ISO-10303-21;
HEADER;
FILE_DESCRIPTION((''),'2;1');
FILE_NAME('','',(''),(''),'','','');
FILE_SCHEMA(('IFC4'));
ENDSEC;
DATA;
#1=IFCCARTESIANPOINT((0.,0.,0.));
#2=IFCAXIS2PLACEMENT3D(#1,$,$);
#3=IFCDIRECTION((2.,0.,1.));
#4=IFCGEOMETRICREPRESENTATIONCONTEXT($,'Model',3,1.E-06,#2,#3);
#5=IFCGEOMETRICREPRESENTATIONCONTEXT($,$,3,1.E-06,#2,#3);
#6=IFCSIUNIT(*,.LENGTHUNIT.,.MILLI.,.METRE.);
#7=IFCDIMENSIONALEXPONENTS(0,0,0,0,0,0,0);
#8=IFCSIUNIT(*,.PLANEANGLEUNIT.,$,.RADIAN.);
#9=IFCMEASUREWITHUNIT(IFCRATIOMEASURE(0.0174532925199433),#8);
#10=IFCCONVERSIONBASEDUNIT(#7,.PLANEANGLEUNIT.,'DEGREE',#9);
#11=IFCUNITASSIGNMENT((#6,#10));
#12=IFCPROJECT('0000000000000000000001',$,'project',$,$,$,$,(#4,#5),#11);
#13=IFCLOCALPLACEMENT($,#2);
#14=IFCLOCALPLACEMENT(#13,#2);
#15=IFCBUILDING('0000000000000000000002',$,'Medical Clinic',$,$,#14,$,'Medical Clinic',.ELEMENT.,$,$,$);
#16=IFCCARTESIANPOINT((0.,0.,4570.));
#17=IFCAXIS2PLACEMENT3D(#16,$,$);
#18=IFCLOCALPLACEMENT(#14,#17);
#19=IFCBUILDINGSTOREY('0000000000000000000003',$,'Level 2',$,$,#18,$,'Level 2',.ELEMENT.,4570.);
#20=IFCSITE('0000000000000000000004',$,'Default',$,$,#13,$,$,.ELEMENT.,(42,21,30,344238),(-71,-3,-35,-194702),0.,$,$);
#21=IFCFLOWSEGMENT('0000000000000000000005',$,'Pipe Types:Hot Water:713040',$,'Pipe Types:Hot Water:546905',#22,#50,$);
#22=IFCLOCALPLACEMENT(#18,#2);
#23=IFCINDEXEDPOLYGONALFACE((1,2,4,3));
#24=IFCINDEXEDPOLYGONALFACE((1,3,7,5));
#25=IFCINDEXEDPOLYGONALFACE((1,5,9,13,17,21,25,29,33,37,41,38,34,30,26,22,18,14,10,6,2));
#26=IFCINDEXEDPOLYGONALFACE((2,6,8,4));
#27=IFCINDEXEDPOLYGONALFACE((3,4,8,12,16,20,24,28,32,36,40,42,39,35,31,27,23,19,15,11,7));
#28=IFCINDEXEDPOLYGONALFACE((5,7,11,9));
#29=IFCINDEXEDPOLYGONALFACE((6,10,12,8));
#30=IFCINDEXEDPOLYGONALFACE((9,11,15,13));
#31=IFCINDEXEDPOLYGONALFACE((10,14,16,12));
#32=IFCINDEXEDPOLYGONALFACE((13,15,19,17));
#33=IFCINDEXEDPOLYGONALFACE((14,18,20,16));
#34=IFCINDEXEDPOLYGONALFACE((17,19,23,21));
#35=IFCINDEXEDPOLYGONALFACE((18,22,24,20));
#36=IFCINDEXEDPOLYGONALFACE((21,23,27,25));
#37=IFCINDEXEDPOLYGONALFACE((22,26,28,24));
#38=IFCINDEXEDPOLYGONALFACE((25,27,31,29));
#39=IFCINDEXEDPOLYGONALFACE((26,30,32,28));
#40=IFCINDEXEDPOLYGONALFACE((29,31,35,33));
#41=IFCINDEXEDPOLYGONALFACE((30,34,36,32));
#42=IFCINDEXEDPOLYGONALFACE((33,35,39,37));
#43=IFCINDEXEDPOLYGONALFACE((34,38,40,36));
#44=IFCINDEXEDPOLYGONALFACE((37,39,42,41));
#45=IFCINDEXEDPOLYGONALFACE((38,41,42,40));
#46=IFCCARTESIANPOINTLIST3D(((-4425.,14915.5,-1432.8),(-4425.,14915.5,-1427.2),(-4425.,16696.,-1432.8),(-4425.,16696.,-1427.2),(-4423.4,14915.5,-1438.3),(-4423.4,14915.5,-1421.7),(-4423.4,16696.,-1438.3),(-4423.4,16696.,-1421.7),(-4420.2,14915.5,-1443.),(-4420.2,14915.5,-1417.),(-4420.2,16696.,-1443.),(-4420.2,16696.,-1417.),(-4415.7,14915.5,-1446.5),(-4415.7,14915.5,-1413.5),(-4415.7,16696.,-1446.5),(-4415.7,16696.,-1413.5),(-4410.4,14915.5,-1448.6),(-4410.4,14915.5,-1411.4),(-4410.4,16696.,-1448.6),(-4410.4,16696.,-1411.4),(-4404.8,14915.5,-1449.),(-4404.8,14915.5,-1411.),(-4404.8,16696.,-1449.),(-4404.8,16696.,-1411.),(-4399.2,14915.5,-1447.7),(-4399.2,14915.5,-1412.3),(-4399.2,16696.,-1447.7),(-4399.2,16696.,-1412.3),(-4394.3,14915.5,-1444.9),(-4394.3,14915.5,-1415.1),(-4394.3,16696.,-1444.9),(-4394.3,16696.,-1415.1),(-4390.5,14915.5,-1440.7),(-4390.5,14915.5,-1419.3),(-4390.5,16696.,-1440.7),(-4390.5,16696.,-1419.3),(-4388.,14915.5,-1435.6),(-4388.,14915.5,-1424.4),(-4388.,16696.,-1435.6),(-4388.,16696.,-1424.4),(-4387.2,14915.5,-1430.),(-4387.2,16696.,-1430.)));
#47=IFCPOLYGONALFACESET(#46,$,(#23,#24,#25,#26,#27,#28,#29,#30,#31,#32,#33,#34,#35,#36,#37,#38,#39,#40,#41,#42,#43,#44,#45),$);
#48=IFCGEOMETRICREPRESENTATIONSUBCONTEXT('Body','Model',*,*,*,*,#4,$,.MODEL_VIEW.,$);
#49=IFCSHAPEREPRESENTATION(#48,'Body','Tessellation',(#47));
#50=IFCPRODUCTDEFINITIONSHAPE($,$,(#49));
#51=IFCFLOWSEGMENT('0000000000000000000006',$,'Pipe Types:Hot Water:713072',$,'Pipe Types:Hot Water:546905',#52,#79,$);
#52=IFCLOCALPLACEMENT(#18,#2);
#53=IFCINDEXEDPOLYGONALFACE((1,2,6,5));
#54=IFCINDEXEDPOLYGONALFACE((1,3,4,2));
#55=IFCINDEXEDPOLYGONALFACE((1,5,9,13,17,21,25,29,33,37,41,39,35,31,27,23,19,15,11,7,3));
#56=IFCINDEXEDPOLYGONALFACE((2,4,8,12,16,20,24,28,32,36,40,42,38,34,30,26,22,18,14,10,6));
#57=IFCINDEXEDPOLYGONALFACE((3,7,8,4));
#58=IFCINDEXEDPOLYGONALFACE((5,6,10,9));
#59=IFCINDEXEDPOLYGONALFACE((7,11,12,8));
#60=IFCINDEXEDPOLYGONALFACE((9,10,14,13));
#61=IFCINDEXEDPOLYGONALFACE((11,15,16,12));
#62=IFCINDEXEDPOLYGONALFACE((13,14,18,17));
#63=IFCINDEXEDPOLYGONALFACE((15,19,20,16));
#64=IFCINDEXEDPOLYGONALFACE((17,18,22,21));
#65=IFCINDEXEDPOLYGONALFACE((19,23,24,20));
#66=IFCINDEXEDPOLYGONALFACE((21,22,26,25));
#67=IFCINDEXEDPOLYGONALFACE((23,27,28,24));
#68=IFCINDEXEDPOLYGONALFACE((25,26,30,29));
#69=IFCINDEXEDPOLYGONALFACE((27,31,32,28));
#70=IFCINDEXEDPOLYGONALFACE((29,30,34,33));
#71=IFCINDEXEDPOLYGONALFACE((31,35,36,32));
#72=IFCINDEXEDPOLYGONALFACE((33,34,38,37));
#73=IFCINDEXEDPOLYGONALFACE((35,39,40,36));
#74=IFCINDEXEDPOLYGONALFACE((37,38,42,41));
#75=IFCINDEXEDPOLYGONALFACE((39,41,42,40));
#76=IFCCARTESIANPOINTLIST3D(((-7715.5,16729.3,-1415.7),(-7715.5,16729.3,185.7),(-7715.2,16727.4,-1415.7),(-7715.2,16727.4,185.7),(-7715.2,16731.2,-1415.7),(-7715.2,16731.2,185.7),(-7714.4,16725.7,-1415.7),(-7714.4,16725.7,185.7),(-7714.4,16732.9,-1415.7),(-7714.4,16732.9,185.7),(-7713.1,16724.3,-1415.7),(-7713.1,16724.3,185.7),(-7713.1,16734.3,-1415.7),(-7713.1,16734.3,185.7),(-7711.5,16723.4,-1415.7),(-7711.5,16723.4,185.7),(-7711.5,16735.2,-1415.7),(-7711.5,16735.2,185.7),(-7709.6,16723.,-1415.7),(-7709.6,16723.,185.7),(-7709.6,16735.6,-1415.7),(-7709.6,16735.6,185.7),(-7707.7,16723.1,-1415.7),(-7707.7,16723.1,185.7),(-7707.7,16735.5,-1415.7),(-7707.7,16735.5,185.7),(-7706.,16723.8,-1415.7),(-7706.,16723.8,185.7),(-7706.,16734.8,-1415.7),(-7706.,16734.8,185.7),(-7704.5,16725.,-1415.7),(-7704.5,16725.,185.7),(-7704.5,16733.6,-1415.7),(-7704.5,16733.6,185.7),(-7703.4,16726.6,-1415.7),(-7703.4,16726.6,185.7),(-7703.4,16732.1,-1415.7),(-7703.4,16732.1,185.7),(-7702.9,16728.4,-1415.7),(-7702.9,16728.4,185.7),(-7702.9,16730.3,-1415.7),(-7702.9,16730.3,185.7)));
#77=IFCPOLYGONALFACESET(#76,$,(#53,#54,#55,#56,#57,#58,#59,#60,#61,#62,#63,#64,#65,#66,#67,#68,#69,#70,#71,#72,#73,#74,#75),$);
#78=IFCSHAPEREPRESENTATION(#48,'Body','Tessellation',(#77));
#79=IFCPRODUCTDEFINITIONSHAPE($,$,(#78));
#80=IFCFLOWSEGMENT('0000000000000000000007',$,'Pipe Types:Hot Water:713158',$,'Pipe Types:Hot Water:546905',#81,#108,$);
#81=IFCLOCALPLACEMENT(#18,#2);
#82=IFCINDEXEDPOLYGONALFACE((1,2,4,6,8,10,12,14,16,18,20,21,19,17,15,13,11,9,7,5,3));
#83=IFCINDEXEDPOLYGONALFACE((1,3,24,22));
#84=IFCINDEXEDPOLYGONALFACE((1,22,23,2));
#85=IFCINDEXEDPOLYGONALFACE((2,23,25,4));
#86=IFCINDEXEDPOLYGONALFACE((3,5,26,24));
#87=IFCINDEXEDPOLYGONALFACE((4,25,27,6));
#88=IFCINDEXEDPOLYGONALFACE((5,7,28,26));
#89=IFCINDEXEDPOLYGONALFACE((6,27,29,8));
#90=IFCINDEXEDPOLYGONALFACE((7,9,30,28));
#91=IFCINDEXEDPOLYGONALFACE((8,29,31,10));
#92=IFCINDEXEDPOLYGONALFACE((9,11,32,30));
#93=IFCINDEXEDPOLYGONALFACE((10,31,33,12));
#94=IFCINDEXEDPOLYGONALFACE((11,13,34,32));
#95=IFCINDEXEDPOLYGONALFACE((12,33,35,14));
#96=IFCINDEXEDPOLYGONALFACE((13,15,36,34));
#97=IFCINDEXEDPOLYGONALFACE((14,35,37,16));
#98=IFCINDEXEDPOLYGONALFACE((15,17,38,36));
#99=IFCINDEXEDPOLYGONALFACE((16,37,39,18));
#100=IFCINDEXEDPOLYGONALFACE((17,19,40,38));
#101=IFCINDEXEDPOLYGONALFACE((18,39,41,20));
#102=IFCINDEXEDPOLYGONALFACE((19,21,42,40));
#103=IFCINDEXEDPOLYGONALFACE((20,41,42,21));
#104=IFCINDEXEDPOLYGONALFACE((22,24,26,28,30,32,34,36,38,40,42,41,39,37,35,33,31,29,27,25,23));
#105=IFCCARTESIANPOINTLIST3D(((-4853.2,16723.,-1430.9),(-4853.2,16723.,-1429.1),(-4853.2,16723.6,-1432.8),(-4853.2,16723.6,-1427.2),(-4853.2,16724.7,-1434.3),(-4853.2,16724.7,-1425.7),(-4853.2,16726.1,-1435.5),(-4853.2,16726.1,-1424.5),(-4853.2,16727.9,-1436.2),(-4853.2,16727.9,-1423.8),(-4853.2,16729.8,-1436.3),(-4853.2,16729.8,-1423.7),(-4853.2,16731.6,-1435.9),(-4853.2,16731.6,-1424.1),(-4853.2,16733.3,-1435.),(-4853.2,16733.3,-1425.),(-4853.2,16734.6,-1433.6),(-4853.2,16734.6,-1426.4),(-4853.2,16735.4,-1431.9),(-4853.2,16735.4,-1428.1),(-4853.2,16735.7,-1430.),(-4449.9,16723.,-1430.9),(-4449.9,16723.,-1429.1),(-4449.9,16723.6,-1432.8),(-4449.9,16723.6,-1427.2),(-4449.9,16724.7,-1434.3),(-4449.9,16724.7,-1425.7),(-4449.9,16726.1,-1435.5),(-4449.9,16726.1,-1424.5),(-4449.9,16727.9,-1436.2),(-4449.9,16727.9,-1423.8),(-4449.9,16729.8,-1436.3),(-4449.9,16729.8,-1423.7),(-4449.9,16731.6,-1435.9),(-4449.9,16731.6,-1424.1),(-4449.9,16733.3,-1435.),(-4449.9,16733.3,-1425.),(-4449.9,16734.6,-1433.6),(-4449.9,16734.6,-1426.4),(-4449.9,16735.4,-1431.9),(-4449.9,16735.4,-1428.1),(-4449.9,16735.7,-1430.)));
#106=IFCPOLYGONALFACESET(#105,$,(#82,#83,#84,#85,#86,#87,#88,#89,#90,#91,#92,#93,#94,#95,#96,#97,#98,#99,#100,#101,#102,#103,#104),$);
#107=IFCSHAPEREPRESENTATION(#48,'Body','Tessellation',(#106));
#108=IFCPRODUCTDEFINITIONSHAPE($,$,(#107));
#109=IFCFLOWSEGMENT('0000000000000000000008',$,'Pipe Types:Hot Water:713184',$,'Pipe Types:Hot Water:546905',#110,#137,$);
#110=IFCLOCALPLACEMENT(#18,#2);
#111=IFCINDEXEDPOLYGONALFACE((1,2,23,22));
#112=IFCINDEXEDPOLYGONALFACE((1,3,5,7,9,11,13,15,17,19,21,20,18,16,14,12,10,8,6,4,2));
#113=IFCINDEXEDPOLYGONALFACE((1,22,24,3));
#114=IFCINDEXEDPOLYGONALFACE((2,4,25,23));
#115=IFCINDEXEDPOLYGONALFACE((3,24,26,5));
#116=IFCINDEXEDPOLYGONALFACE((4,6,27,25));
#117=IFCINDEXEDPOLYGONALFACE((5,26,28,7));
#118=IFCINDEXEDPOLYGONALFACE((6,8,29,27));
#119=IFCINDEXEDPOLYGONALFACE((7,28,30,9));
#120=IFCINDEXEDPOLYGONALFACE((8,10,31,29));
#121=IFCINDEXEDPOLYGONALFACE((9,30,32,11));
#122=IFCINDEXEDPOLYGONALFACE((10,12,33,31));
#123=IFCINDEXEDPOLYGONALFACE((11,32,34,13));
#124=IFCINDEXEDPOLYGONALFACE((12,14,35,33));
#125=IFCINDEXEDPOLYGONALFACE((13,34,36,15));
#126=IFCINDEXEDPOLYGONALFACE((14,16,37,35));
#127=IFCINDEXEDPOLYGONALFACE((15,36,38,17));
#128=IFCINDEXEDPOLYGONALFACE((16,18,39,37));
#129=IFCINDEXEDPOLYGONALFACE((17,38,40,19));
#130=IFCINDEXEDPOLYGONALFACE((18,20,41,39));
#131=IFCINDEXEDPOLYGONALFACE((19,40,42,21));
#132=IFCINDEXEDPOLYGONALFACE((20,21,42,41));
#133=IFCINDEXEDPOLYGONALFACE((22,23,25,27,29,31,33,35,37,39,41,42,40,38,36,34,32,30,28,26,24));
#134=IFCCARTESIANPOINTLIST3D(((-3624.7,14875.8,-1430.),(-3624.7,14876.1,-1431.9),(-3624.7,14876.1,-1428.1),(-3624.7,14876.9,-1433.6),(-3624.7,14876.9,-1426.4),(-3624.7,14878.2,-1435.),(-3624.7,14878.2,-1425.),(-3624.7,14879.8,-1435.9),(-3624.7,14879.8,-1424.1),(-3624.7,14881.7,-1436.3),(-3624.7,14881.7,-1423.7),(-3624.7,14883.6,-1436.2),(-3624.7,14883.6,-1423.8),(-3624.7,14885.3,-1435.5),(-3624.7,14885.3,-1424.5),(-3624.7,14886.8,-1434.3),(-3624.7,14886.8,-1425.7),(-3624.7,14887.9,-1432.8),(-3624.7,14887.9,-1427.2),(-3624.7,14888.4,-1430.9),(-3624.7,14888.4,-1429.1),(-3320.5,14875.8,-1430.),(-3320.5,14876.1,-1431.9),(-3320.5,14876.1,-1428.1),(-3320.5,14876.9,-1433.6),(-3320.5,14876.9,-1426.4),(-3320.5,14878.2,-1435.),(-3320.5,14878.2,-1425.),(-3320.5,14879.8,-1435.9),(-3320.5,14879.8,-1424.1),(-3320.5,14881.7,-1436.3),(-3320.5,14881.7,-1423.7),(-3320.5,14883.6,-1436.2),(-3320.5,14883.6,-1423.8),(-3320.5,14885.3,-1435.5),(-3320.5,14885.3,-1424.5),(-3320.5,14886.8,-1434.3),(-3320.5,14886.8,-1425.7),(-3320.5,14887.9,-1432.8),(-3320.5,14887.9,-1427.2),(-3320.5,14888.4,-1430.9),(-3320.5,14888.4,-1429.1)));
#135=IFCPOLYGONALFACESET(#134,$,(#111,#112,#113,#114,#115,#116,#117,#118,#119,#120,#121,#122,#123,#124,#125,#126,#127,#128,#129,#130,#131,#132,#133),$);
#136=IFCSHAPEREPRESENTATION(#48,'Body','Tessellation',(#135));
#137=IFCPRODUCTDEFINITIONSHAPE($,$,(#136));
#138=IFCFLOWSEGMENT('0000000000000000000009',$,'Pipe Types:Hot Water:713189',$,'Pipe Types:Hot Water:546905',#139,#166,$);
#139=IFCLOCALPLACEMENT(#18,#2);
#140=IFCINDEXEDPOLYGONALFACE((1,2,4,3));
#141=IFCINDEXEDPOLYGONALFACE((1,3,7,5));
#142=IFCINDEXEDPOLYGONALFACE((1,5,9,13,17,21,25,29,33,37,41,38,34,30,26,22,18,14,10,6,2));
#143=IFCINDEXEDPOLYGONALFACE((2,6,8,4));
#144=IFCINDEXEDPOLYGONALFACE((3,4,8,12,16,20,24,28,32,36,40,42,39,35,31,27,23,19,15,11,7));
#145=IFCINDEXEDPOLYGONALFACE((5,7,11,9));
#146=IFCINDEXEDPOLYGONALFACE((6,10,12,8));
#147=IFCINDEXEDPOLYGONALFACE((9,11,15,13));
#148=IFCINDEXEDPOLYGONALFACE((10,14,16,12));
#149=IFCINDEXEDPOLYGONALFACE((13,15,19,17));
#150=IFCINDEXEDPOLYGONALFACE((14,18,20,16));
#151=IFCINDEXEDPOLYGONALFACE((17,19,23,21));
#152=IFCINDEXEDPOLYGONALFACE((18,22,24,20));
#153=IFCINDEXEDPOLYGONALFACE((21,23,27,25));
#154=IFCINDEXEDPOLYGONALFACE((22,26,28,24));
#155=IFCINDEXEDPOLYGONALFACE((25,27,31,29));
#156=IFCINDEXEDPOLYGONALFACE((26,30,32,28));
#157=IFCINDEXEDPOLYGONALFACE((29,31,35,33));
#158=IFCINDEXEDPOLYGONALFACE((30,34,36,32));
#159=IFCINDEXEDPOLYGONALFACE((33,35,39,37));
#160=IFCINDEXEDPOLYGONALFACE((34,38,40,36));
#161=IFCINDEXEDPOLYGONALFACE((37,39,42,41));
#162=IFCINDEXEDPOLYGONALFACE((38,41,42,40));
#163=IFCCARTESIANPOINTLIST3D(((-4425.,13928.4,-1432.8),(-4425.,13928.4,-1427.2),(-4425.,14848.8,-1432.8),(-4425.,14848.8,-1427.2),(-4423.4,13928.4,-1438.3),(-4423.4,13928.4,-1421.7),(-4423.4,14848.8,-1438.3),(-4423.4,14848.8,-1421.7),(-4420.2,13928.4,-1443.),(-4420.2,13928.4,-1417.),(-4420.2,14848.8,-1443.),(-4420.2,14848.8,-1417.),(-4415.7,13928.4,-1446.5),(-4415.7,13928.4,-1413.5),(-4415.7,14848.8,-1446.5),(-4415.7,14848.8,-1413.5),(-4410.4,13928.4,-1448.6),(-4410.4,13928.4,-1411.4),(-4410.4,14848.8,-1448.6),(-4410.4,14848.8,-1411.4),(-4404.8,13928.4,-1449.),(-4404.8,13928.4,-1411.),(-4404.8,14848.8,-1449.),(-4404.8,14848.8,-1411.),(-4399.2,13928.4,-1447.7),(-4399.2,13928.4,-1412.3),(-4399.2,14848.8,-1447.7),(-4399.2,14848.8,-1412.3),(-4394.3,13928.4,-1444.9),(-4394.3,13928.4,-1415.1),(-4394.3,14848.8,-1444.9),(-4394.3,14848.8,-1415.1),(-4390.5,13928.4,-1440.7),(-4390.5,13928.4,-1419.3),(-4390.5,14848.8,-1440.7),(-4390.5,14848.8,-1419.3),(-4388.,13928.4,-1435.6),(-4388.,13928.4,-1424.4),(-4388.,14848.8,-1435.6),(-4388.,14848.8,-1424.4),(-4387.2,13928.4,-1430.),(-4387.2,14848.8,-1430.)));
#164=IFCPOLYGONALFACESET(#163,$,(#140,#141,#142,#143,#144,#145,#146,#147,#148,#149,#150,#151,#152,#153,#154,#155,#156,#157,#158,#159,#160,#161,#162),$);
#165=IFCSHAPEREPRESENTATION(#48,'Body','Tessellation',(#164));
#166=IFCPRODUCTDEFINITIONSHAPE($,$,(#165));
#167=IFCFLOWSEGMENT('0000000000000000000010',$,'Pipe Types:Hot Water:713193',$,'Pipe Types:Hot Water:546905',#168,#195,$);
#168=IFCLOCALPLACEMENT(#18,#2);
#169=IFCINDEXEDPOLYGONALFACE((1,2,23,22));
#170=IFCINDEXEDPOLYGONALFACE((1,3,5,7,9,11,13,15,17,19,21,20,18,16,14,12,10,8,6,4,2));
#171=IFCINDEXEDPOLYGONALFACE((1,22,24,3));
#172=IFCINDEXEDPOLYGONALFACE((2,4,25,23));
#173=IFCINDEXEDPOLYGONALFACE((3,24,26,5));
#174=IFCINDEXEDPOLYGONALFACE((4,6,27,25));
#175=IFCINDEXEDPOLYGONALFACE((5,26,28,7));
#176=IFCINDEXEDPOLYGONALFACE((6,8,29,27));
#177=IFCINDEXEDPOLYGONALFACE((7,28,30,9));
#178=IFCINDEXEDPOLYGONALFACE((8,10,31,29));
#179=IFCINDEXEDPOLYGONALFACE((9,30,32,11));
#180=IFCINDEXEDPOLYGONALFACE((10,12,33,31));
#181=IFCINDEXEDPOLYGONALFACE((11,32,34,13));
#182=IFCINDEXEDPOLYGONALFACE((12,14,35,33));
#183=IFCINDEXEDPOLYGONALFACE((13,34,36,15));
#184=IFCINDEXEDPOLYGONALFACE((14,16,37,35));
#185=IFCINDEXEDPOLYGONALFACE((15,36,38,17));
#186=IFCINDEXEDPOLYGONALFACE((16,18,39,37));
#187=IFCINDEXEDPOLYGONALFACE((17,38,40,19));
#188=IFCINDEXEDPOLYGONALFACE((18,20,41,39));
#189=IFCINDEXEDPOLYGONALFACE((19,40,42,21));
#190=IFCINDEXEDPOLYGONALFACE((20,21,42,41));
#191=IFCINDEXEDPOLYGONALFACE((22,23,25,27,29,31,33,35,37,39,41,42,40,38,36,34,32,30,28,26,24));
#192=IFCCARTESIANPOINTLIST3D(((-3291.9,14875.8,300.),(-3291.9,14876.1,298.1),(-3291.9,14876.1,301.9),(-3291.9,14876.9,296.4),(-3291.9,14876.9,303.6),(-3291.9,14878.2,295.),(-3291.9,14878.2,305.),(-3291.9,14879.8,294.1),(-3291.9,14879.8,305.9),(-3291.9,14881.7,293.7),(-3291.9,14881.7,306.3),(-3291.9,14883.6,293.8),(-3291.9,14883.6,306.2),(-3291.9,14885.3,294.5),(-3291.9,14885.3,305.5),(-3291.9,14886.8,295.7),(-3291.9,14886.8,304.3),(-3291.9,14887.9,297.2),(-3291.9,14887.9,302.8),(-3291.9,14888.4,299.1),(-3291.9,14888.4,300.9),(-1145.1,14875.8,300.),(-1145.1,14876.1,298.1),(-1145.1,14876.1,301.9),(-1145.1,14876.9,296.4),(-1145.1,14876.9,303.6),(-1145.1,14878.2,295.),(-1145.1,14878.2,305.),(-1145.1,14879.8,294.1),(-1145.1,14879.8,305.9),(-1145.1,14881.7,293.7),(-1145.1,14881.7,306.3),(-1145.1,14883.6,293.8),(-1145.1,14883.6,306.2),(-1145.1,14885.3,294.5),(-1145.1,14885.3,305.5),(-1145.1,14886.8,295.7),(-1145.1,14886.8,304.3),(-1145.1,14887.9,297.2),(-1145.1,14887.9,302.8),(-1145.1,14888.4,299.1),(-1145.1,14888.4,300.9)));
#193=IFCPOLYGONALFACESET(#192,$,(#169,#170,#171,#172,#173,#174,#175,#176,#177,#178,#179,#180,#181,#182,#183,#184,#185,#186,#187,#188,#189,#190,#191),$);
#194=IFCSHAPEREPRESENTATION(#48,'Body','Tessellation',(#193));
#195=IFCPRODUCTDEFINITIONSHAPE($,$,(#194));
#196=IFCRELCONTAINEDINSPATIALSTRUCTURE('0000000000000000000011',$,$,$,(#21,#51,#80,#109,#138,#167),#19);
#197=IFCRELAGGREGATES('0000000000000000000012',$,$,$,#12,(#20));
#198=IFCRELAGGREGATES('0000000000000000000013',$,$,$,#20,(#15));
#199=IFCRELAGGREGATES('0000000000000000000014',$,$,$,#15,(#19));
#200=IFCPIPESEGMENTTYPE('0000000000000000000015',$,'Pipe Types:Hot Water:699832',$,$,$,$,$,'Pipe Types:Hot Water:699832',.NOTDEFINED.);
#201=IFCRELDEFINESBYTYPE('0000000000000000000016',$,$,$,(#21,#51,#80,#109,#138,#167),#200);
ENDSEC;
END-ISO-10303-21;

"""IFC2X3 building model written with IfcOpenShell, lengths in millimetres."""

from ifc_helpers import new_model, entity, si_unit, converted_unit, direction, frame, origin, origin_2d_with_axis, place, context, subcontext, project, spatial, circle, extrude, type_object, element, save


model = new_model("IFC2X3")

# Units and contexts
model_context = context("Model", 3, precision=1e-06, world=origin(), true_north=direction((2.0, 0.0, 1.0)))
context_of_model = context(None, 3, precision=1e-06, world=origin(), true_north=direction((2.0, 0.0, 1.0)))
body_context = subcontext(model_context, "Body", "Model", "MODEL_VIEW")
ifc_project = project(units=[si_unit("LENGTHUNIT", "METRE", prefix="MILLI"), converted_unit("PLANEANGLEUNIT", "DEGREE", entity("IfcRatioMeasure", 0.0174532925199433), si_unit("PLANEANGLEUNIT", "RADIAN"), dimensions=[0, 0, 0, 0, 0, 0, 0])], contexts=[model_context, context_of_model])

# Site, building, storey
site_placement = place(None, origin())
site = spatial("IfcSite", under=ifc_project, at=site_placement, Name="Default", CompositionType="ELEMENT", RefLatitude=(42, 21, 30, 344238), RefLongitude=(-71, -3, -35, -194702), RefElevation=0.0)
building_placement = place(site_placement, origin())
building = spatial("IfcBuilding", under=site, at=building_placement, Name="Medical Clinic", LongName="Medical Clinic", CompositionType="ELEMENT")
storey_placement = place(building_placement, frame((0.0, 0.0, 4570.0)))
storey = spatial("IfcBuildingStorey", under=building, at=storey_placement, Name="Level 2", LongName="Level 2", CompositionType="ELEMENT", Elevation=4570.0)

# Flow segments
pipe_segment_type_1 = type_object("IfcPipeSegmentType", Name="Pipe Types:Hot Water:699832", ElementType="Pipe Types:Hot Water:699832", PredefinedType="NOTDEFINED")
flow_segment_1_placement = place(storey_placement, origin())
element("IfcFlowSegment", 1, at=flow_segment_1_placement, inside=storey, type_object=pipe_segment_type_1, Name="Pipe Types:Hot Water:713040", ObjectType="Pipe Types:Hot Water:546905", context=body_context, shape_type="SweptSolid", body=[
    extrude(circle(Radius=19.1, at=origin_2d_with_axis()), frame((-4406.2, 14915.5, -1430.0), z_axis=(0.0, 1.0, 0.0), x_axis=(1.0, 0.0, 0.0)), (0.0, 0.0, 1.0), 1780.5),
])
flow_segment_2_placement = place(storey_placement, origin())
element("IfcFlowSegment", 2, at=flow_segment_2_placement, inside=storey, type_object=pipe_segment_type_1, Name="Pipe Types:Hot Water:713072", ObjectType="Pipe Types:Hot Water:546905", context=body_context, shape_type="SweptSolid", body=[
    extrude(circle(Radius=6.3, at=origin_2d_with_axis()), frame((-7709.1, 16729.3, -1415.7), z_axis=(0.0, 0.0, 1.0), x_axis=(-1.0, 0.0, 0.0)), (0.0, 0.0, 1.0), 1601.4),
])
flow_segment_3_placement = place(storey_placement, origin())
element("IfcFlowSegment", 3, at=flow_segment_3_placement, inside=storey, type_object=pipe_segment_type_1, Name="Pipe Types:Hot Water:713158", ObjectType="Pipe Types:Hot Water:546905", context=body_context, shape_type="SweptSolid", body=[
    extrude(circle(Radius=6.3, at=origin_2d_with_axis()), frame((-4853.2, 16729.3, -1430.0), z_axis=(1.0, 0.0, 0.0), x_axis=(0.0, 1.0, 0.0)), (0.0, 0.0, 1.0), 403.3),
])
flow_segment_4_placement = place(storey_placement, origin())
element("IfcFlowSegment", 4, at=flow_segment_4_placement, inside=storey, type_object=pipe_segment_type_1, Name="Pipe Types:Hot Water:713184", ObjectType="Pipe Types:Hot Water:546905", context=body_context, shape_type="SweptSolid", body=[
    extrude(circle(Radius=6.3, at=origin_2d_with_axis()), frame((-3624.7, 14882.2, -1430.0), z_axis=(1.0, 0.0, 0.0), x_axis=(0.0, -1.0, 0.0)), (0.0, 0.0, 1.0), 304.2),
])
flow_segment_5_placement = place(storey_placement, origin())
element("IfcFlowSegment", 5, at=flow_segment_5_placement, inside=storey, type_object=pipe_segment_type_1, Name="Pipe Types:Hot Water:713189", ObjectType="Pipe Types:Hot Water:546905", context=body_context, shape_type="SweptSolid", body=[
    extrude(circle(Radius=19.1, at=origin_2d_with_axis()), frame((-4406.2, 13928.4, -1430.0), z_axis=(0.0, 1.0, 0.0), x_axis=(1.0, 0.0, 0.0)), (0.0, 0.0, 1.0), 920.4),
])
flow_segment_6_placement = place(storey_placement, origin())
element("IfcFlowSegment", 6, at=flow_segment_6_placement, inside=storey, type_object=pipe_segment_type_1, Name="Pipe Types:Hot Water:713193", ObjectType="Pipe Types:Hot Water:546905", context=body_context, shape_type="SweptSolid", body=[
    extrude(circle(Radius=6.3, at=origin_2d_with_axis()), frame((-3291.9, 14882.2, 300.0), z_axis=(1.0, 0.0, 0.0), x_axis=(0.0, -1.0, 0.0)), (0.0, 0.0, 1.0), 2146.8),
])

save(model, "model.ifc")
